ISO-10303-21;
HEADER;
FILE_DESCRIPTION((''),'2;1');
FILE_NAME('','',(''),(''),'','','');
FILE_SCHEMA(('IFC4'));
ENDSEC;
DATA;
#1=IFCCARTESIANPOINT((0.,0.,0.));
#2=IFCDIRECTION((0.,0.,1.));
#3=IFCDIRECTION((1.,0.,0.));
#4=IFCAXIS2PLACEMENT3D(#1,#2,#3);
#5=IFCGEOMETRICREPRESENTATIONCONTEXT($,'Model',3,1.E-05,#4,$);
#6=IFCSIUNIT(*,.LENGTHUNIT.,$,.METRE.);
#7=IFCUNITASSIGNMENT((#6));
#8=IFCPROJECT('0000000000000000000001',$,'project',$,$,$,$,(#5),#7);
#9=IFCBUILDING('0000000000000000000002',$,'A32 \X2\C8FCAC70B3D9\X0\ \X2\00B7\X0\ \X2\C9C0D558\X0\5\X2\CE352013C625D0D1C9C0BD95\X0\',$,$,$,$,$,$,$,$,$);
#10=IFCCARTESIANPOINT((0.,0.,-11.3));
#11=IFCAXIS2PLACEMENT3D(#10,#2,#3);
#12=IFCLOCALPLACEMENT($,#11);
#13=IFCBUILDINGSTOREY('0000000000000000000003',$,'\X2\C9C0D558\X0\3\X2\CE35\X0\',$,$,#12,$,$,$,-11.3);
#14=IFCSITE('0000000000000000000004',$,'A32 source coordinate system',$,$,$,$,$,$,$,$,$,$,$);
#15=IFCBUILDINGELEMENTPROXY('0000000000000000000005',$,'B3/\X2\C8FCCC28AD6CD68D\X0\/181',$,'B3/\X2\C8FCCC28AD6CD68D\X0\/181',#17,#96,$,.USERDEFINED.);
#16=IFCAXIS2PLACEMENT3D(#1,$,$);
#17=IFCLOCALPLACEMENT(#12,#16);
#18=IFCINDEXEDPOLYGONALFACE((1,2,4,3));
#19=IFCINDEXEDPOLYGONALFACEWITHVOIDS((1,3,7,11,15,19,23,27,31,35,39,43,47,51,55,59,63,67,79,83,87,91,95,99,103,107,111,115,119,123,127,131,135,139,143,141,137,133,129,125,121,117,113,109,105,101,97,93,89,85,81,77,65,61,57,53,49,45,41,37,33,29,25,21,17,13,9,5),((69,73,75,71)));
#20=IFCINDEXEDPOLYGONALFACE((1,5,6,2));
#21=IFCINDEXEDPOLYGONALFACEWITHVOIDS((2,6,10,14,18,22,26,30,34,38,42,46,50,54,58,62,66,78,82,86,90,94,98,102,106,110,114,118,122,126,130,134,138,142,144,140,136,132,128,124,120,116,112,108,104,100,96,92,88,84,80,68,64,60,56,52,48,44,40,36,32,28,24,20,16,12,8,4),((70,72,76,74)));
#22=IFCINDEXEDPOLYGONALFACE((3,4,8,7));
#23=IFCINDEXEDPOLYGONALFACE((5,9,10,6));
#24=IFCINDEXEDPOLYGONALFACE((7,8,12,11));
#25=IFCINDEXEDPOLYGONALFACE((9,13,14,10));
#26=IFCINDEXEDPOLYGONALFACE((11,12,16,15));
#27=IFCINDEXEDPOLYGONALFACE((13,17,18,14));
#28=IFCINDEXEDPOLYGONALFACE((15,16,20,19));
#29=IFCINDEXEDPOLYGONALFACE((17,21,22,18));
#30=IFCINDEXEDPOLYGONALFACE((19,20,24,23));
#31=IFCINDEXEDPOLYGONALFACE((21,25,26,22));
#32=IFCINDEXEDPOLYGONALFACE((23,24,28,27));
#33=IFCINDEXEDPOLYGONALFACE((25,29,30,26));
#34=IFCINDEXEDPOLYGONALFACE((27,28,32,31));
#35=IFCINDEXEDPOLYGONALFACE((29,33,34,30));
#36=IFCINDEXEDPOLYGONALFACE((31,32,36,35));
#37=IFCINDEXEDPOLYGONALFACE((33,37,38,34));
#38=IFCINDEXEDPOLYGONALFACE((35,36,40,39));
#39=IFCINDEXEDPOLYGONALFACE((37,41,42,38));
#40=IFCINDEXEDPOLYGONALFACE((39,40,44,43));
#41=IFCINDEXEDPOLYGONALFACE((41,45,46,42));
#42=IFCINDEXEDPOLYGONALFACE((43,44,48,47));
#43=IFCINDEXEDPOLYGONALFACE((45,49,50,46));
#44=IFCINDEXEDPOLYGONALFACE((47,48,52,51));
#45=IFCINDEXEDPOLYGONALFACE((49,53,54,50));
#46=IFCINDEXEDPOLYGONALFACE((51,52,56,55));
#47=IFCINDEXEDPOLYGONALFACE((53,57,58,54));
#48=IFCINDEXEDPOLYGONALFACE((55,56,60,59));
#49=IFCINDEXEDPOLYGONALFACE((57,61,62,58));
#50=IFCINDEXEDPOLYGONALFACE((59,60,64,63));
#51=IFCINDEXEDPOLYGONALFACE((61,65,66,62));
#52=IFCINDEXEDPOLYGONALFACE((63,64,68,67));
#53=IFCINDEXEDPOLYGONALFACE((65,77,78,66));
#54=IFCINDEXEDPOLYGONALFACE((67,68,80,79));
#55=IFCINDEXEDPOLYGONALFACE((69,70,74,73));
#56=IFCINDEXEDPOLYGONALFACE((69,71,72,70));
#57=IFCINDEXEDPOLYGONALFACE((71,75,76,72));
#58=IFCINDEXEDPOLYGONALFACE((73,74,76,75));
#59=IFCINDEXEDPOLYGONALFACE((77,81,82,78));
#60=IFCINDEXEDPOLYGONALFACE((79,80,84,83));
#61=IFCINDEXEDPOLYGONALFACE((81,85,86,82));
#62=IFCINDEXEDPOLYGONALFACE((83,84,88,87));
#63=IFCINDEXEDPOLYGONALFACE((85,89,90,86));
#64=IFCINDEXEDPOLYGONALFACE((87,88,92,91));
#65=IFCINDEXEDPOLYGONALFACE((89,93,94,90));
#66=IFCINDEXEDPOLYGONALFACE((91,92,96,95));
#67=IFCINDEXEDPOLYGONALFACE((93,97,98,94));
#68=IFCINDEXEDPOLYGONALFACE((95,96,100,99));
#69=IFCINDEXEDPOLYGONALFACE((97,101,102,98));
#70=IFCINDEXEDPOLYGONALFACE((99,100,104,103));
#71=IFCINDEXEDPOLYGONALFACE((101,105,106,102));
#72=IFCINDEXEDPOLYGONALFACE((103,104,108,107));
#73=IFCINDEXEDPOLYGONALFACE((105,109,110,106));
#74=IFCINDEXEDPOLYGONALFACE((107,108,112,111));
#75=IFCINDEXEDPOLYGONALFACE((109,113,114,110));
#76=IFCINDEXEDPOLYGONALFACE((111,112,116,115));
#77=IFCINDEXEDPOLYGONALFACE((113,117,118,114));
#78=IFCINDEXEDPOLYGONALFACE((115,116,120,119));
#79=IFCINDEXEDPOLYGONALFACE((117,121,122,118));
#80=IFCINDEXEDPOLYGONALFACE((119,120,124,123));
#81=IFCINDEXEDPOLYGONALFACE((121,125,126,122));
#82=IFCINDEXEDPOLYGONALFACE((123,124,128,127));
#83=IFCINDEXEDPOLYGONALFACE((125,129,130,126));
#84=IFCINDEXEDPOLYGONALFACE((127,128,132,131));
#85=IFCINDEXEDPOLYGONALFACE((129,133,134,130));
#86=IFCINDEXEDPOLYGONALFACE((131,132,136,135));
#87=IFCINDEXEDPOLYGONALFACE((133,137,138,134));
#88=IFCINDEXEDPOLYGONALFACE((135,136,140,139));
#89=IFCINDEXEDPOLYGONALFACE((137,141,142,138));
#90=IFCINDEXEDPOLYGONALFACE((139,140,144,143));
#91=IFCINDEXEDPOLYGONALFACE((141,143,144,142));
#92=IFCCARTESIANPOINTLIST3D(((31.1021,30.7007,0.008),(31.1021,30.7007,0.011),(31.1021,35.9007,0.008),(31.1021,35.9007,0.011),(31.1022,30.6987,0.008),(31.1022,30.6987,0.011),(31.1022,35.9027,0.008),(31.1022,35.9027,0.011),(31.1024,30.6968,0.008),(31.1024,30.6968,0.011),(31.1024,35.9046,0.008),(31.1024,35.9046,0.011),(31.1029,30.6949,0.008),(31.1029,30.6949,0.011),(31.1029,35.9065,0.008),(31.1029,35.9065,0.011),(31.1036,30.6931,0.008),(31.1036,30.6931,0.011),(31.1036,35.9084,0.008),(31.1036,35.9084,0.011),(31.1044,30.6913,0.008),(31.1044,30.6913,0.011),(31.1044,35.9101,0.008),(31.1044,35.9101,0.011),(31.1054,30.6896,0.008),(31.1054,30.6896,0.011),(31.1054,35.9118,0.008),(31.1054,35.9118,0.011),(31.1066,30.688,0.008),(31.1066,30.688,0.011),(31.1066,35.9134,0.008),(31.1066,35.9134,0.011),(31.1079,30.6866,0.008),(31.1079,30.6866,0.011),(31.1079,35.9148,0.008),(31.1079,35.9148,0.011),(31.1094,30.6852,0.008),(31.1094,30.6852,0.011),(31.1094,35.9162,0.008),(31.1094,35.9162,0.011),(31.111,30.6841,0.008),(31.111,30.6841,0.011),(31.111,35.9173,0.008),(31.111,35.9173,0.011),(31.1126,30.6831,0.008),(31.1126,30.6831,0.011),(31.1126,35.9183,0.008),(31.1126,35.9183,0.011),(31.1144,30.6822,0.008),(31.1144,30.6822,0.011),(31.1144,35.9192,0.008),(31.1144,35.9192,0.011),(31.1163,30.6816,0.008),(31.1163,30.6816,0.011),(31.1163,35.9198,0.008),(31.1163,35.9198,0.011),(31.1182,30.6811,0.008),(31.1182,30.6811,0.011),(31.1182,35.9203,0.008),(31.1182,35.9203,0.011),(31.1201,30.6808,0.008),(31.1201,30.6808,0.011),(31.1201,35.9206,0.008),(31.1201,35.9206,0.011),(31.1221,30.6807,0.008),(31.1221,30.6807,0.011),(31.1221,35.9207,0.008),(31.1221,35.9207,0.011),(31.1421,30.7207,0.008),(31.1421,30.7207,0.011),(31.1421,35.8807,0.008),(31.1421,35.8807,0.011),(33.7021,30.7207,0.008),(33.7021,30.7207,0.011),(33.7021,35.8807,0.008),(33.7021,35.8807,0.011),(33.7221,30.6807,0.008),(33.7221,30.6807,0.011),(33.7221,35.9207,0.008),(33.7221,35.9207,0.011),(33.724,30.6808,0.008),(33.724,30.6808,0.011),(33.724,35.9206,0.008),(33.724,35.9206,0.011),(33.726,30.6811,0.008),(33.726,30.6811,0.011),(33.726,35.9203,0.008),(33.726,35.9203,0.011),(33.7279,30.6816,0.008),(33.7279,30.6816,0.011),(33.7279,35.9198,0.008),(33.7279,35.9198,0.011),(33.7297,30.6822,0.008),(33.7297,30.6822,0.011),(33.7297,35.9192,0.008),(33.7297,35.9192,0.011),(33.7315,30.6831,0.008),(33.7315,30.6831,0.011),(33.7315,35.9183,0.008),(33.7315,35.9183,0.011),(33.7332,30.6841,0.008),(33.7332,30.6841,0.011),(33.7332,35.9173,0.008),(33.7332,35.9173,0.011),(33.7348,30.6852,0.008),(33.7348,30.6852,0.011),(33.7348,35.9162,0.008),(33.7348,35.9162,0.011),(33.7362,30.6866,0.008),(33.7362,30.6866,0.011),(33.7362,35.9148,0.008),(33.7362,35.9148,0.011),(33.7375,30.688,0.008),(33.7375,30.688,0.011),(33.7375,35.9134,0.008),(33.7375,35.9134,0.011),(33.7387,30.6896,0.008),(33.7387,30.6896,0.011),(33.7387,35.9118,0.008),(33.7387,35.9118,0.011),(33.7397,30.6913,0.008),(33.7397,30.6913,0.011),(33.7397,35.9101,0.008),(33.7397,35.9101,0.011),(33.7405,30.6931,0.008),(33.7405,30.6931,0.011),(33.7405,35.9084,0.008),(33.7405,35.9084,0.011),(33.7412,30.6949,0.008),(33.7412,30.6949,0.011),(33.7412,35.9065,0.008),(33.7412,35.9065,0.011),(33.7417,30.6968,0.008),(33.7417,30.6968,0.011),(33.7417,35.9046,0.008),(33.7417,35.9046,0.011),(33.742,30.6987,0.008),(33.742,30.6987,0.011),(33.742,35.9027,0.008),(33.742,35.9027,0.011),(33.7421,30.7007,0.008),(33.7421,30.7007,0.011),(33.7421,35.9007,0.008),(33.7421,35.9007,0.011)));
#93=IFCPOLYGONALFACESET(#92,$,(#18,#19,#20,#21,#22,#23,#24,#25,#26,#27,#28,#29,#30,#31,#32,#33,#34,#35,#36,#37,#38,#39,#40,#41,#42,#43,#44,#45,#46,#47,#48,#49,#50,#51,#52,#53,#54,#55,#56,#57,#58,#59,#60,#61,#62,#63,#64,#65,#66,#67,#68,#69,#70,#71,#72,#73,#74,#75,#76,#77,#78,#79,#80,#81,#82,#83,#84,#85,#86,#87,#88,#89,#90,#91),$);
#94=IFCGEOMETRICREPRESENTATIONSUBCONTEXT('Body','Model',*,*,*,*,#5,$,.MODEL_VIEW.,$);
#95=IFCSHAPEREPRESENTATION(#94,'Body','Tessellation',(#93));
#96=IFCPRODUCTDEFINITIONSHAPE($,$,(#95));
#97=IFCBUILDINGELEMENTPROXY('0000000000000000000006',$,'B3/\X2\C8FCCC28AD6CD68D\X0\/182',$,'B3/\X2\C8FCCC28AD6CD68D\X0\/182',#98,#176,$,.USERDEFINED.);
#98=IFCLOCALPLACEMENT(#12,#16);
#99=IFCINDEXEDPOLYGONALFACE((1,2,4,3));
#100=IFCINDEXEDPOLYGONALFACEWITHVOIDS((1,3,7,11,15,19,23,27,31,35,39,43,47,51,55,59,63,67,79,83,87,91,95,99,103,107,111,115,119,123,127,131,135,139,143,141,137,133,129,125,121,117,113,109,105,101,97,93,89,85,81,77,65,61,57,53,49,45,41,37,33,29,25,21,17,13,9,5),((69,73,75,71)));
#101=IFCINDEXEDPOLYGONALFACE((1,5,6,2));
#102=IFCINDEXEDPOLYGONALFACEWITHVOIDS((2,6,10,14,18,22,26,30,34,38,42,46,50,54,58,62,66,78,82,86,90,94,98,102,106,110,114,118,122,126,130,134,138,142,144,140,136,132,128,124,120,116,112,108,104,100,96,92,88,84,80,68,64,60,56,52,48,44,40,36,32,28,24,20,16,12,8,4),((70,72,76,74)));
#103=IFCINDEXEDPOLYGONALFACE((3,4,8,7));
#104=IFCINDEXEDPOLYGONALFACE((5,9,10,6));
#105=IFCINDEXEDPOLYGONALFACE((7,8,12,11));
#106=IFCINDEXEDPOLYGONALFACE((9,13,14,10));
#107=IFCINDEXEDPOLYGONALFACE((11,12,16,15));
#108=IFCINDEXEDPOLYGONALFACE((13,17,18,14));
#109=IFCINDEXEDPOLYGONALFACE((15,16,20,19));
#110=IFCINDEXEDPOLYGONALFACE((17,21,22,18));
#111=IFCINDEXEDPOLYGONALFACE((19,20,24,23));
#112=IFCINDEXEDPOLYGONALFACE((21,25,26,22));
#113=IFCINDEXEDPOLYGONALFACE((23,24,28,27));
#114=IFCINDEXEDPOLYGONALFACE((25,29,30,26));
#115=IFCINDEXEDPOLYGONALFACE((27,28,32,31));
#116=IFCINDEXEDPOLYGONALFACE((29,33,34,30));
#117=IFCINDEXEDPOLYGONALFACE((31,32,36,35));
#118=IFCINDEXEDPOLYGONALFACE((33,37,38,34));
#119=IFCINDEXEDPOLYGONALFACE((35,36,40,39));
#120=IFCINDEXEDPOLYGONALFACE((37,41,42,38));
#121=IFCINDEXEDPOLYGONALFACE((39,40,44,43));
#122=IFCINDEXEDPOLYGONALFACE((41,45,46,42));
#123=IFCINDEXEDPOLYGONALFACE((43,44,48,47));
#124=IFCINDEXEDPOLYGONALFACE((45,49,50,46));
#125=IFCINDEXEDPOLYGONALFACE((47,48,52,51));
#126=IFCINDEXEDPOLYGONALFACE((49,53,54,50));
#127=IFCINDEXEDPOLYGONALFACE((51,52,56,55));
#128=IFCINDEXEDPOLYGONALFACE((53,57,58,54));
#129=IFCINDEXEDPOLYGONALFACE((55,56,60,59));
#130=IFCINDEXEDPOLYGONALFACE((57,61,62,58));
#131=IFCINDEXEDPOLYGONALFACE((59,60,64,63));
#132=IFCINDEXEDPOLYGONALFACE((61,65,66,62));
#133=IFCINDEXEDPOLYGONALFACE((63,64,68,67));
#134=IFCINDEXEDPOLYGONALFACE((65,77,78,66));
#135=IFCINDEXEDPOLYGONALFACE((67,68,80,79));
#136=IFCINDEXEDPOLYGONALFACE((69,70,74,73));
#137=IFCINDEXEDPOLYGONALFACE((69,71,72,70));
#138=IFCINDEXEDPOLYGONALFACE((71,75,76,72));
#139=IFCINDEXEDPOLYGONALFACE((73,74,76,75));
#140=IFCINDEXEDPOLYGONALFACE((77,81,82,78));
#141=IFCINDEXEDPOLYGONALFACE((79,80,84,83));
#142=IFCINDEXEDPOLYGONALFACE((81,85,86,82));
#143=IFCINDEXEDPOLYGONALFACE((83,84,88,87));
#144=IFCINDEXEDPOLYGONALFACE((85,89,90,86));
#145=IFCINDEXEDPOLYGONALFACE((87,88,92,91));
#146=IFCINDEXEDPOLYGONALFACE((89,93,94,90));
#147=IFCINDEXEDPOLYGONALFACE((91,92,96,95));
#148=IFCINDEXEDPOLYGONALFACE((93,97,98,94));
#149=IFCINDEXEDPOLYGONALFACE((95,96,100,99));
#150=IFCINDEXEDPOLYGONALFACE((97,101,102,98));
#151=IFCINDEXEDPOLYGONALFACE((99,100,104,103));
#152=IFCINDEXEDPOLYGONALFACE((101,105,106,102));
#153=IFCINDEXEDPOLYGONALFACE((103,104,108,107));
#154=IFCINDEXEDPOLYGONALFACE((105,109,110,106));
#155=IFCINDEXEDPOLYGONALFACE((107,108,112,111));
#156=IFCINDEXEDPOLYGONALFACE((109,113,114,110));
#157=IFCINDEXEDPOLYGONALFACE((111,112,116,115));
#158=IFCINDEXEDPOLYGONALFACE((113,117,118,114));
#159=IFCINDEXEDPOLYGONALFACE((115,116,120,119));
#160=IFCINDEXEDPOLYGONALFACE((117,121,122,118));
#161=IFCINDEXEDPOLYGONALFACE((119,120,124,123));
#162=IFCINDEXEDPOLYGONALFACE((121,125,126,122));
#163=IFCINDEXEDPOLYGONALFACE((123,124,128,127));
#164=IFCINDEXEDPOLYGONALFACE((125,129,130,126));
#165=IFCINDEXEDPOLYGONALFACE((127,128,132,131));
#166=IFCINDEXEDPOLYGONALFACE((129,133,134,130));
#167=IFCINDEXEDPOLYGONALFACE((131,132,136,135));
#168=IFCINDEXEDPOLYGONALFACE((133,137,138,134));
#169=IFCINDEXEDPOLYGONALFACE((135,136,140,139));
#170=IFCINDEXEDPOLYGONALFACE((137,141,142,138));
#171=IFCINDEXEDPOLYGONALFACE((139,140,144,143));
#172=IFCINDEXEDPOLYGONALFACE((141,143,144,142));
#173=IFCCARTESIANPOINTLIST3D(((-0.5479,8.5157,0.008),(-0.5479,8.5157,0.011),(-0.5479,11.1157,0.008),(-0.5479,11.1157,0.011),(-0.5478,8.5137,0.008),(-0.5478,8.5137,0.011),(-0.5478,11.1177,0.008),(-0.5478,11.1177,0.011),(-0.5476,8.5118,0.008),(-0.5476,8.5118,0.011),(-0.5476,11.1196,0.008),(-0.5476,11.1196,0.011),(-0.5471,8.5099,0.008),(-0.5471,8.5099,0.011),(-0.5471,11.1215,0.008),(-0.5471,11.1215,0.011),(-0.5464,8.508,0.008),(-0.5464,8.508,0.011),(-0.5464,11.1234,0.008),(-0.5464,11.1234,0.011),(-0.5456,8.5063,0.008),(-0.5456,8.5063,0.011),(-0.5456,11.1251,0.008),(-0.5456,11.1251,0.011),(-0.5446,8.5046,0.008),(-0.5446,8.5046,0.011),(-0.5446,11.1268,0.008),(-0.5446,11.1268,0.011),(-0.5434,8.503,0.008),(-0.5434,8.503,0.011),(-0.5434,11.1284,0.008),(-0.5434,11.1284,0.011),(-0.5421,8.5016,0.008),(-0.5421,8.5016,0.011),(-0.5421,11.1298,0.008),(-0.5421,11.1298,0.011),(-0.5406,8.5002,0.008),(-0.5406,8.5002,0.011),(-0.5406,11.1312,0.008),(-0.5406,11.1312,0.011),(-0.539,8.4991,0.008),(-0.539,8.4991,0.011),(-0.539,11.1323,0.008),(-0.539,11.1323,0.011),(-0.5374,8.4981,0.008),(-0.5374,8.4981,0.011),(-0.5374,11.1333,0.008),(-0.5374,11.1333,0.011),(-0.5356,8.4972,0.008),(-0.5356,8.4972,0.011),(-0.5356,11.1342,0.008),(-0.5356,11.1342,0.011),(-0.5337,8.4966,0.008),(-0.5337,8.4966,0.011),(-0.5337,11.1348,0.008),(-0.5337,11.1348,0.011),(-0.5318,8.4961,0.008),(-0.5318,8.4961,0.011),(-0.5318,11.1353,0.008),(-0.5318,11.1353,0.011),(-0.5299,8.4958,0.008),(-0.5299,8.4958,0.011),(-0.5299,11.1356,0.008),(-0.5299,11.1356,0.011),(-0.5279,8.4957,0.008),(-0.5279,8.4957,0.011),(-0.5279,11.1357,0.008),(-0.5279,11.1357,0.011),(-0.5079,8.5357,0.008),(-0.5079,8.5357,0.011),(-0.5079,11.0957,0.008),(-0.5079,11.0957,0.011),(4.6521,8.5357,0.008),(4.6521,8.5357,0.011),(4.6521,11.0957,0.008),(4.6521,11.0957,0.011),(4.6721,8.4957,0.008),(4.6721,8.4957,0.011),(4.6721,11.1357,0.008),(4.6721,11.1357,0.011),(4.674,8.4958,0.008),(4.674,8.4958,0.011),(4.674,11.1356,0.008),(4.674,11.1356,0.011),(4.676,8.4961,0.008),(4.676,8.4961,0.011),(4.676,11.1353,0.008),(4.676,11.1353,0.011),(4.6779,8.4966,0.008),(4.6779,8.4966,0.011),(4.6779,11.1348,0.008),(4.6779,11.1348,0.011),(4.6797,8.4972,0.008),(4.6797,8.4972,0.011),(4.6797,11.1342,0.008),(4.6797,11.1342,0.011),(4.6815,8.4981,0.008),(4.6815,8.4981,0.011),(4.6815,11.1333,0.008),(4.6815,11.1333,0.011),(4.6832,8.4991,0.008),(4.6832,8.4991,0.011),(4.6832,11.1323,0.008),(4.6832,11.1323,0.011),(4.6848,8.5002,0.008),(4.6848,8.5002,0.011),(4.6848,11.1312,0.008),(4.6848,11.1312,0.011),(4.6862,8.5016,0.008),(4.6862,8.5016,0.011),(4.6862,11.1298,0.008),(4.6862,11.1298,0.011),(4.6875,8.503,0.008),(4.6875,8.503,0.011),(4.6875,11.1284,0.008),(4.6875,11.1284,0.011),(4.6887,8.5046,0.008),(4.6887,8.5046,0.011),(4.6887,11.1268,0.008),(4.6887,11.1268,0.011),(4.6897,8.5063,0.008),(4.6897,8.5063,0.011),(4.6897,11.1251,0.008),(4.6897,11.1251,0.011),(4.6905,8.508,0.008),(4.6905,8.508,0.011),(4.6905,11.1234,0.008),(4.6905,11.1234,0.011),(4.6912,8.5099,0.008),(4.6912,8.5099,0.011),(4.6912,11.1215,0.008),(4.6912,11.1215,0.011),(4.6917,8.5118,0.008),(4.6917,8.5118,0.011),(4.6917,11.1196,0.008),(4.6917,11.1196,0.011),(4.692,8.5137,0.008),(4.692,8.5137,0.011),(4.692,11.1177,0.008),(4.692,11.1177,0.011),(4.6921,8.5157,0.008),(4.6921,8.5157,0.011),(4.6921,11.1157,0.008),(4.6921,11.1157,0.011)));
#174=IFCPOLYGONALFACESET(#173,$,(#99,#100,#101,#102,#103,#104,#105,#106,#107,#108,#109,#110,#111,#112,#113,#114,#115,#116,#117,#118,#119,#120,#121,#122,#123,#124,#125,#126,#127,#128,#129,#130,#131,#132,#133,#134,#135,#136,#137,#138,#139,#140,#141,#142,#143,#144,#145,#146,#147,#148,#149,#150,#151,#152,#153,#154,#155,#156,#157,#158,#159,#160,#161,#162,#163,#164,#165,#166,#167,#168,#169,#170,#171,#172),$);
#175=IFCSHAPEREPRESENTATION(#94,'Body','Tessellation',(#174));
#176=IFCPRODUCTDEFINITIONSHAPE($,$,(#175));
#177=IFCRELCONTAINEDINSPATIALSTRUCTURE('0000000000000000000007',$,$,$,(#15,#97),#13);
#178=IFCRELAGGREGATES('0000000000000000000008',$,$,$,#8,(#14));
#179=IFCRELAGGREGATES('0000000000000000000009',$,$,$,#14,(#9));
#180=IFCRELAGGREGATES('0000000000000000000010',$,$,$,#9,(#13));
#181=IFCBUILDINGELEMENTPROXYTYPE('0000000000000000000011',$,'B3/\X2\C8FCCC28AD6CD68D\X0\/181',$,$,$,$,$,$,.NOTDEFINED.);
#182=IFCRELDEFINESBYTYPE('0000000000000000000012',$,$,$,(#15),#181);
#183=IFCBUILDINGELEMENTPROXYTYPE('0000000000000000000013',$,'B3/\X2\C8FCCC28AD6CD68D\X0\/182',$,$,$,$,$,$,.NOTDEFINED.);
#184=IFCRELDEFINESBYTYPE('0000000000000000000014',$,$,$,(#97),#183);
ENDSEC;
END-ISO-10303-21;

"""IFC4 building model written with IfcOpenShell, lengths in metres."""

from ifc_helpers import new_model, si_unit, frame, origin, origin_with_axes, place, context, subcontext, project, spatial, polyline, outline, extrude, source, transform, mapped, type_object, type_shapes, element, save


model = new_model("IFC4")

# Units and contexts
model_context = context("Model", 3, precision=1e-05, world=origin_with_axes())
body_context = subcontext(model_context, "Body", "Model", "MODEL_VIEW")
ifc_project = project(units=[si_unit("LENGTHUNIT", "METRE")], contexts=[model_context])

# Site, building, storey
site = spatial("IfcSite", under=ifc_project, Name="A32 source coordinate system")
building = spatial("IfcBuilding", under=site, Name="A32 주거동 · 지하5층–옥탑지붕")
storey_placement = place(None, frame((0.0, 0.0, -11.3), z_axis=(0.0, 0.0, 1.0), x_axis=(1.0, 0.0, 0.0)))
storey = spatial("IfcBuildingStorey", under=building, at=storey_placement, Name="지하3층", Elevation=-11.3)

# Building element proxies
building_element_proxy_type_1 = type_object("IfcBuildingElementProxyType", Name="B3/주차구획/181", PredefinedType="NOTDEFINED")
shared_shape_1 = source(origin(), body_context, "Body", "SweptSolid", [
    extrude(outline(polyline([(31.1021, 35.9007), (31.1022, 35.9027), (31.1024, 35.9046), (31.1029, 35.9065), (31.1036, 35.9084), (31.1044, 35.9101), (31.1054, 35.9118), (31.1066, 35.9134), (31.1079, 35.9148), (31.1094, 35.9162), (31.111, 35.9173), (31.1126, 35.9183), (31.1144, 35.9192), (31.1163, 35.9198), (31.1182, 35.9203), (31.1201, 35.9206), (31.1221, 35.9207), (33.7221, 35.9207), (33.724, 35.9206), (33.726, 35.9203), (33.7279, 35.9198), (33.7297, 35.9192), (33.7315, 35.9183), (33.7332, 35.9173), (33.7348, 35.9162), (33.7362, 35.9148), (33.7375, 35.9134), (33.7387, 35.9118), (33.7397, 35.9101), (33.7405, 35.9084), (33.7412, 35.9065), (33.7417, 35.9046), (33.742, 35.9027), (33.7421, 35.9007), (33.7421, 30.7007), (33.742, 30.6987), (33.7417, 30.6968), (33.7412, 30.6949), (33.7405, 30.6931), (33.7397, 30.6913), (33.7387, 30.6896), (33.7375, 30.688), (33.7362, 30.6866), (33.7348, 30.6852), (33.7332, 30.6841), (33.7315, 30.6831), (33.7297, 30.6822), (33.7279, 30.6816), (33.726, 30.6811), (33.724, 30.6808), (33.7221, 30.6807), (31.1221, 30.6807), (31.1201, 30.6808), (31.1182, 30.6811), (31.1163, 30.6816), (31.1144, 30.6822), (31.1126, 30.6831), (31.111, 30.6841), (31.1094, 30.6852), (31.1079, 30.6866), (31.1066, 30.688), (31.1054, 30.6896), (31.1044, 30.6913), (31.1036, 30.6931), (31.1029, 30.6949), (31.1024, 30.6968), (31.1022, 30.6987), (31.1021, 30.7007), (31.1021, 35.9007)]), holes=[polyline([(31.1421, 35.8807), (31.1421, 30.7207), (33.7021, 30.7207), (33.7021, 35.8807), (31.1421, 35.8807)])]), frame((0.0, 0.0, 0.008)), (0.0, 0.0, 1.0), 0.003),
])
type_shapes(building_element_proxy_type_1, [shared_shape_1])
proxy_1_placement = place(storey_placement, origin_with_axes())
element("IfcBuildingElementProxy", 1, at=proxy_1_placement, inside=storey, type_object=building_element_proxy_type_1, Name="B3/주차구획/181", ObjectType="B3/주차구획/181", PredefinedType="USERDEFINED", context=body_context, shape_type="MappedRepresentation", body=[
    mapped(shared_shape_1, transform((0.0, 0.0, 0.0), scale=1.0)),
])
building_element_proxy_type_2 = type_object("IfcBuildingElementProxyType", Name="B3/주차구획/182", PredefinedType="NOTDEFINED")
shared_shape_2 = source(origin(), body_context, "Body", "SweptSolid", [
    extrude(outline(polyline([(-0.5279, 8.4957), (-0.5299, 8.4958), (-0.5318, 8.4961), (-0.5337, 8.4966), (-0.5356, 8.4972), (-0.5374, 8.4981), (-0.539, 8.4991), (-0.5406, 8.5002), (-0.5421, 8.5016), (-0.5434, 8.503), (-0.5446, 8.5046), (-0.5456, 8.5063), (-0.5464, 8.508), (-0.5471, 8.5099), (-0.5476, 8.5118), (-0.5478, 8.5137), (-0.5479, 8.5157), (-0.5479, 11.1157), (-0.5478, 11.1177), (-0.5476, 11.1196), (-0.5471, 11.1215), (-0.5464, 11.1234), (-0.5456, 11.1251), (-0.5446, 11.1268), (-0.5434, 11.1284), (-0.5421, 11.1298), (-0.5406, 11.1312), (-0.539, 11.1323), (-0.5374, 11.1333), (-0.5356, 11.1342), (-0.5337, 11.1348), (-0.5318, 11.1353), (-0.5299, 11.1356), (-0.5279, 11.1357), (4.6721, 11.1357), (4.674, 11.1356), (4.676, 11.1353), (4.6779, 11.1348), (4.6797, 11.1342), (4.6815, 11.1333), (4.6832, 11.1323), (4.6848, 11.1312), (4.6862, 11.1298), (4.6875, 11.1284), (4.6887, 11.1268), (4.6897, 11.1251), (4.6905, 11.1234), (4.6912, 11.1215), (4.6917, 11.1196), (4.692, 11.1177), (4.6921, 11.1157), (4.6921, 8.5157), (4.692, 8.5137), (4.6917, 8.5118), (4.6912, 8.5099), (4.6905, 8.508), (4.6897, 8.5063), (4.6887, 8.5046), (4.6875, 8.503), (4.6862, 8.5016), (4.6848, 8.5002), (4.6832, 8.4991), (4.6815, 8.4981), (4.6797, 8.4972), (4.6779, 8.4966), (4.676, 8.4961), (4.674, 8.4958), (4.6721, 8.4957), (-0.5279, 8.4957)]), holes=[polyline([(-0.5079, 8.5357), (4.6521, 8.5357), (4.6521, 11.0957), (-0.5079, 11.0957), (-0.5079, 8.5357)])]), frame((0.0, 0.0, 0.008)), (0.0, 0.0, 1.0), 0.003),
])
type_shapes(building_element_proxy_type_2, [shared_shape_2])
proxy_2_placement = place(storey_placement, origin_with_axes())
element("IfcBuildingElementProxy", 2, at=proxy_2_placement, inside=storey, type_object=building_element_proxy_type_2, Name="B3/주차구획/182", ObjectType="B3/주차구획/182", PredefinedType="USERDEFINED", context=body_context, shape_type="MappedRepresentation", body=[
    mapped(shared_shape_2, transform((0.0, 0.0, 0.0), scale=1.0)),
])

save(model, "model.ifc")
